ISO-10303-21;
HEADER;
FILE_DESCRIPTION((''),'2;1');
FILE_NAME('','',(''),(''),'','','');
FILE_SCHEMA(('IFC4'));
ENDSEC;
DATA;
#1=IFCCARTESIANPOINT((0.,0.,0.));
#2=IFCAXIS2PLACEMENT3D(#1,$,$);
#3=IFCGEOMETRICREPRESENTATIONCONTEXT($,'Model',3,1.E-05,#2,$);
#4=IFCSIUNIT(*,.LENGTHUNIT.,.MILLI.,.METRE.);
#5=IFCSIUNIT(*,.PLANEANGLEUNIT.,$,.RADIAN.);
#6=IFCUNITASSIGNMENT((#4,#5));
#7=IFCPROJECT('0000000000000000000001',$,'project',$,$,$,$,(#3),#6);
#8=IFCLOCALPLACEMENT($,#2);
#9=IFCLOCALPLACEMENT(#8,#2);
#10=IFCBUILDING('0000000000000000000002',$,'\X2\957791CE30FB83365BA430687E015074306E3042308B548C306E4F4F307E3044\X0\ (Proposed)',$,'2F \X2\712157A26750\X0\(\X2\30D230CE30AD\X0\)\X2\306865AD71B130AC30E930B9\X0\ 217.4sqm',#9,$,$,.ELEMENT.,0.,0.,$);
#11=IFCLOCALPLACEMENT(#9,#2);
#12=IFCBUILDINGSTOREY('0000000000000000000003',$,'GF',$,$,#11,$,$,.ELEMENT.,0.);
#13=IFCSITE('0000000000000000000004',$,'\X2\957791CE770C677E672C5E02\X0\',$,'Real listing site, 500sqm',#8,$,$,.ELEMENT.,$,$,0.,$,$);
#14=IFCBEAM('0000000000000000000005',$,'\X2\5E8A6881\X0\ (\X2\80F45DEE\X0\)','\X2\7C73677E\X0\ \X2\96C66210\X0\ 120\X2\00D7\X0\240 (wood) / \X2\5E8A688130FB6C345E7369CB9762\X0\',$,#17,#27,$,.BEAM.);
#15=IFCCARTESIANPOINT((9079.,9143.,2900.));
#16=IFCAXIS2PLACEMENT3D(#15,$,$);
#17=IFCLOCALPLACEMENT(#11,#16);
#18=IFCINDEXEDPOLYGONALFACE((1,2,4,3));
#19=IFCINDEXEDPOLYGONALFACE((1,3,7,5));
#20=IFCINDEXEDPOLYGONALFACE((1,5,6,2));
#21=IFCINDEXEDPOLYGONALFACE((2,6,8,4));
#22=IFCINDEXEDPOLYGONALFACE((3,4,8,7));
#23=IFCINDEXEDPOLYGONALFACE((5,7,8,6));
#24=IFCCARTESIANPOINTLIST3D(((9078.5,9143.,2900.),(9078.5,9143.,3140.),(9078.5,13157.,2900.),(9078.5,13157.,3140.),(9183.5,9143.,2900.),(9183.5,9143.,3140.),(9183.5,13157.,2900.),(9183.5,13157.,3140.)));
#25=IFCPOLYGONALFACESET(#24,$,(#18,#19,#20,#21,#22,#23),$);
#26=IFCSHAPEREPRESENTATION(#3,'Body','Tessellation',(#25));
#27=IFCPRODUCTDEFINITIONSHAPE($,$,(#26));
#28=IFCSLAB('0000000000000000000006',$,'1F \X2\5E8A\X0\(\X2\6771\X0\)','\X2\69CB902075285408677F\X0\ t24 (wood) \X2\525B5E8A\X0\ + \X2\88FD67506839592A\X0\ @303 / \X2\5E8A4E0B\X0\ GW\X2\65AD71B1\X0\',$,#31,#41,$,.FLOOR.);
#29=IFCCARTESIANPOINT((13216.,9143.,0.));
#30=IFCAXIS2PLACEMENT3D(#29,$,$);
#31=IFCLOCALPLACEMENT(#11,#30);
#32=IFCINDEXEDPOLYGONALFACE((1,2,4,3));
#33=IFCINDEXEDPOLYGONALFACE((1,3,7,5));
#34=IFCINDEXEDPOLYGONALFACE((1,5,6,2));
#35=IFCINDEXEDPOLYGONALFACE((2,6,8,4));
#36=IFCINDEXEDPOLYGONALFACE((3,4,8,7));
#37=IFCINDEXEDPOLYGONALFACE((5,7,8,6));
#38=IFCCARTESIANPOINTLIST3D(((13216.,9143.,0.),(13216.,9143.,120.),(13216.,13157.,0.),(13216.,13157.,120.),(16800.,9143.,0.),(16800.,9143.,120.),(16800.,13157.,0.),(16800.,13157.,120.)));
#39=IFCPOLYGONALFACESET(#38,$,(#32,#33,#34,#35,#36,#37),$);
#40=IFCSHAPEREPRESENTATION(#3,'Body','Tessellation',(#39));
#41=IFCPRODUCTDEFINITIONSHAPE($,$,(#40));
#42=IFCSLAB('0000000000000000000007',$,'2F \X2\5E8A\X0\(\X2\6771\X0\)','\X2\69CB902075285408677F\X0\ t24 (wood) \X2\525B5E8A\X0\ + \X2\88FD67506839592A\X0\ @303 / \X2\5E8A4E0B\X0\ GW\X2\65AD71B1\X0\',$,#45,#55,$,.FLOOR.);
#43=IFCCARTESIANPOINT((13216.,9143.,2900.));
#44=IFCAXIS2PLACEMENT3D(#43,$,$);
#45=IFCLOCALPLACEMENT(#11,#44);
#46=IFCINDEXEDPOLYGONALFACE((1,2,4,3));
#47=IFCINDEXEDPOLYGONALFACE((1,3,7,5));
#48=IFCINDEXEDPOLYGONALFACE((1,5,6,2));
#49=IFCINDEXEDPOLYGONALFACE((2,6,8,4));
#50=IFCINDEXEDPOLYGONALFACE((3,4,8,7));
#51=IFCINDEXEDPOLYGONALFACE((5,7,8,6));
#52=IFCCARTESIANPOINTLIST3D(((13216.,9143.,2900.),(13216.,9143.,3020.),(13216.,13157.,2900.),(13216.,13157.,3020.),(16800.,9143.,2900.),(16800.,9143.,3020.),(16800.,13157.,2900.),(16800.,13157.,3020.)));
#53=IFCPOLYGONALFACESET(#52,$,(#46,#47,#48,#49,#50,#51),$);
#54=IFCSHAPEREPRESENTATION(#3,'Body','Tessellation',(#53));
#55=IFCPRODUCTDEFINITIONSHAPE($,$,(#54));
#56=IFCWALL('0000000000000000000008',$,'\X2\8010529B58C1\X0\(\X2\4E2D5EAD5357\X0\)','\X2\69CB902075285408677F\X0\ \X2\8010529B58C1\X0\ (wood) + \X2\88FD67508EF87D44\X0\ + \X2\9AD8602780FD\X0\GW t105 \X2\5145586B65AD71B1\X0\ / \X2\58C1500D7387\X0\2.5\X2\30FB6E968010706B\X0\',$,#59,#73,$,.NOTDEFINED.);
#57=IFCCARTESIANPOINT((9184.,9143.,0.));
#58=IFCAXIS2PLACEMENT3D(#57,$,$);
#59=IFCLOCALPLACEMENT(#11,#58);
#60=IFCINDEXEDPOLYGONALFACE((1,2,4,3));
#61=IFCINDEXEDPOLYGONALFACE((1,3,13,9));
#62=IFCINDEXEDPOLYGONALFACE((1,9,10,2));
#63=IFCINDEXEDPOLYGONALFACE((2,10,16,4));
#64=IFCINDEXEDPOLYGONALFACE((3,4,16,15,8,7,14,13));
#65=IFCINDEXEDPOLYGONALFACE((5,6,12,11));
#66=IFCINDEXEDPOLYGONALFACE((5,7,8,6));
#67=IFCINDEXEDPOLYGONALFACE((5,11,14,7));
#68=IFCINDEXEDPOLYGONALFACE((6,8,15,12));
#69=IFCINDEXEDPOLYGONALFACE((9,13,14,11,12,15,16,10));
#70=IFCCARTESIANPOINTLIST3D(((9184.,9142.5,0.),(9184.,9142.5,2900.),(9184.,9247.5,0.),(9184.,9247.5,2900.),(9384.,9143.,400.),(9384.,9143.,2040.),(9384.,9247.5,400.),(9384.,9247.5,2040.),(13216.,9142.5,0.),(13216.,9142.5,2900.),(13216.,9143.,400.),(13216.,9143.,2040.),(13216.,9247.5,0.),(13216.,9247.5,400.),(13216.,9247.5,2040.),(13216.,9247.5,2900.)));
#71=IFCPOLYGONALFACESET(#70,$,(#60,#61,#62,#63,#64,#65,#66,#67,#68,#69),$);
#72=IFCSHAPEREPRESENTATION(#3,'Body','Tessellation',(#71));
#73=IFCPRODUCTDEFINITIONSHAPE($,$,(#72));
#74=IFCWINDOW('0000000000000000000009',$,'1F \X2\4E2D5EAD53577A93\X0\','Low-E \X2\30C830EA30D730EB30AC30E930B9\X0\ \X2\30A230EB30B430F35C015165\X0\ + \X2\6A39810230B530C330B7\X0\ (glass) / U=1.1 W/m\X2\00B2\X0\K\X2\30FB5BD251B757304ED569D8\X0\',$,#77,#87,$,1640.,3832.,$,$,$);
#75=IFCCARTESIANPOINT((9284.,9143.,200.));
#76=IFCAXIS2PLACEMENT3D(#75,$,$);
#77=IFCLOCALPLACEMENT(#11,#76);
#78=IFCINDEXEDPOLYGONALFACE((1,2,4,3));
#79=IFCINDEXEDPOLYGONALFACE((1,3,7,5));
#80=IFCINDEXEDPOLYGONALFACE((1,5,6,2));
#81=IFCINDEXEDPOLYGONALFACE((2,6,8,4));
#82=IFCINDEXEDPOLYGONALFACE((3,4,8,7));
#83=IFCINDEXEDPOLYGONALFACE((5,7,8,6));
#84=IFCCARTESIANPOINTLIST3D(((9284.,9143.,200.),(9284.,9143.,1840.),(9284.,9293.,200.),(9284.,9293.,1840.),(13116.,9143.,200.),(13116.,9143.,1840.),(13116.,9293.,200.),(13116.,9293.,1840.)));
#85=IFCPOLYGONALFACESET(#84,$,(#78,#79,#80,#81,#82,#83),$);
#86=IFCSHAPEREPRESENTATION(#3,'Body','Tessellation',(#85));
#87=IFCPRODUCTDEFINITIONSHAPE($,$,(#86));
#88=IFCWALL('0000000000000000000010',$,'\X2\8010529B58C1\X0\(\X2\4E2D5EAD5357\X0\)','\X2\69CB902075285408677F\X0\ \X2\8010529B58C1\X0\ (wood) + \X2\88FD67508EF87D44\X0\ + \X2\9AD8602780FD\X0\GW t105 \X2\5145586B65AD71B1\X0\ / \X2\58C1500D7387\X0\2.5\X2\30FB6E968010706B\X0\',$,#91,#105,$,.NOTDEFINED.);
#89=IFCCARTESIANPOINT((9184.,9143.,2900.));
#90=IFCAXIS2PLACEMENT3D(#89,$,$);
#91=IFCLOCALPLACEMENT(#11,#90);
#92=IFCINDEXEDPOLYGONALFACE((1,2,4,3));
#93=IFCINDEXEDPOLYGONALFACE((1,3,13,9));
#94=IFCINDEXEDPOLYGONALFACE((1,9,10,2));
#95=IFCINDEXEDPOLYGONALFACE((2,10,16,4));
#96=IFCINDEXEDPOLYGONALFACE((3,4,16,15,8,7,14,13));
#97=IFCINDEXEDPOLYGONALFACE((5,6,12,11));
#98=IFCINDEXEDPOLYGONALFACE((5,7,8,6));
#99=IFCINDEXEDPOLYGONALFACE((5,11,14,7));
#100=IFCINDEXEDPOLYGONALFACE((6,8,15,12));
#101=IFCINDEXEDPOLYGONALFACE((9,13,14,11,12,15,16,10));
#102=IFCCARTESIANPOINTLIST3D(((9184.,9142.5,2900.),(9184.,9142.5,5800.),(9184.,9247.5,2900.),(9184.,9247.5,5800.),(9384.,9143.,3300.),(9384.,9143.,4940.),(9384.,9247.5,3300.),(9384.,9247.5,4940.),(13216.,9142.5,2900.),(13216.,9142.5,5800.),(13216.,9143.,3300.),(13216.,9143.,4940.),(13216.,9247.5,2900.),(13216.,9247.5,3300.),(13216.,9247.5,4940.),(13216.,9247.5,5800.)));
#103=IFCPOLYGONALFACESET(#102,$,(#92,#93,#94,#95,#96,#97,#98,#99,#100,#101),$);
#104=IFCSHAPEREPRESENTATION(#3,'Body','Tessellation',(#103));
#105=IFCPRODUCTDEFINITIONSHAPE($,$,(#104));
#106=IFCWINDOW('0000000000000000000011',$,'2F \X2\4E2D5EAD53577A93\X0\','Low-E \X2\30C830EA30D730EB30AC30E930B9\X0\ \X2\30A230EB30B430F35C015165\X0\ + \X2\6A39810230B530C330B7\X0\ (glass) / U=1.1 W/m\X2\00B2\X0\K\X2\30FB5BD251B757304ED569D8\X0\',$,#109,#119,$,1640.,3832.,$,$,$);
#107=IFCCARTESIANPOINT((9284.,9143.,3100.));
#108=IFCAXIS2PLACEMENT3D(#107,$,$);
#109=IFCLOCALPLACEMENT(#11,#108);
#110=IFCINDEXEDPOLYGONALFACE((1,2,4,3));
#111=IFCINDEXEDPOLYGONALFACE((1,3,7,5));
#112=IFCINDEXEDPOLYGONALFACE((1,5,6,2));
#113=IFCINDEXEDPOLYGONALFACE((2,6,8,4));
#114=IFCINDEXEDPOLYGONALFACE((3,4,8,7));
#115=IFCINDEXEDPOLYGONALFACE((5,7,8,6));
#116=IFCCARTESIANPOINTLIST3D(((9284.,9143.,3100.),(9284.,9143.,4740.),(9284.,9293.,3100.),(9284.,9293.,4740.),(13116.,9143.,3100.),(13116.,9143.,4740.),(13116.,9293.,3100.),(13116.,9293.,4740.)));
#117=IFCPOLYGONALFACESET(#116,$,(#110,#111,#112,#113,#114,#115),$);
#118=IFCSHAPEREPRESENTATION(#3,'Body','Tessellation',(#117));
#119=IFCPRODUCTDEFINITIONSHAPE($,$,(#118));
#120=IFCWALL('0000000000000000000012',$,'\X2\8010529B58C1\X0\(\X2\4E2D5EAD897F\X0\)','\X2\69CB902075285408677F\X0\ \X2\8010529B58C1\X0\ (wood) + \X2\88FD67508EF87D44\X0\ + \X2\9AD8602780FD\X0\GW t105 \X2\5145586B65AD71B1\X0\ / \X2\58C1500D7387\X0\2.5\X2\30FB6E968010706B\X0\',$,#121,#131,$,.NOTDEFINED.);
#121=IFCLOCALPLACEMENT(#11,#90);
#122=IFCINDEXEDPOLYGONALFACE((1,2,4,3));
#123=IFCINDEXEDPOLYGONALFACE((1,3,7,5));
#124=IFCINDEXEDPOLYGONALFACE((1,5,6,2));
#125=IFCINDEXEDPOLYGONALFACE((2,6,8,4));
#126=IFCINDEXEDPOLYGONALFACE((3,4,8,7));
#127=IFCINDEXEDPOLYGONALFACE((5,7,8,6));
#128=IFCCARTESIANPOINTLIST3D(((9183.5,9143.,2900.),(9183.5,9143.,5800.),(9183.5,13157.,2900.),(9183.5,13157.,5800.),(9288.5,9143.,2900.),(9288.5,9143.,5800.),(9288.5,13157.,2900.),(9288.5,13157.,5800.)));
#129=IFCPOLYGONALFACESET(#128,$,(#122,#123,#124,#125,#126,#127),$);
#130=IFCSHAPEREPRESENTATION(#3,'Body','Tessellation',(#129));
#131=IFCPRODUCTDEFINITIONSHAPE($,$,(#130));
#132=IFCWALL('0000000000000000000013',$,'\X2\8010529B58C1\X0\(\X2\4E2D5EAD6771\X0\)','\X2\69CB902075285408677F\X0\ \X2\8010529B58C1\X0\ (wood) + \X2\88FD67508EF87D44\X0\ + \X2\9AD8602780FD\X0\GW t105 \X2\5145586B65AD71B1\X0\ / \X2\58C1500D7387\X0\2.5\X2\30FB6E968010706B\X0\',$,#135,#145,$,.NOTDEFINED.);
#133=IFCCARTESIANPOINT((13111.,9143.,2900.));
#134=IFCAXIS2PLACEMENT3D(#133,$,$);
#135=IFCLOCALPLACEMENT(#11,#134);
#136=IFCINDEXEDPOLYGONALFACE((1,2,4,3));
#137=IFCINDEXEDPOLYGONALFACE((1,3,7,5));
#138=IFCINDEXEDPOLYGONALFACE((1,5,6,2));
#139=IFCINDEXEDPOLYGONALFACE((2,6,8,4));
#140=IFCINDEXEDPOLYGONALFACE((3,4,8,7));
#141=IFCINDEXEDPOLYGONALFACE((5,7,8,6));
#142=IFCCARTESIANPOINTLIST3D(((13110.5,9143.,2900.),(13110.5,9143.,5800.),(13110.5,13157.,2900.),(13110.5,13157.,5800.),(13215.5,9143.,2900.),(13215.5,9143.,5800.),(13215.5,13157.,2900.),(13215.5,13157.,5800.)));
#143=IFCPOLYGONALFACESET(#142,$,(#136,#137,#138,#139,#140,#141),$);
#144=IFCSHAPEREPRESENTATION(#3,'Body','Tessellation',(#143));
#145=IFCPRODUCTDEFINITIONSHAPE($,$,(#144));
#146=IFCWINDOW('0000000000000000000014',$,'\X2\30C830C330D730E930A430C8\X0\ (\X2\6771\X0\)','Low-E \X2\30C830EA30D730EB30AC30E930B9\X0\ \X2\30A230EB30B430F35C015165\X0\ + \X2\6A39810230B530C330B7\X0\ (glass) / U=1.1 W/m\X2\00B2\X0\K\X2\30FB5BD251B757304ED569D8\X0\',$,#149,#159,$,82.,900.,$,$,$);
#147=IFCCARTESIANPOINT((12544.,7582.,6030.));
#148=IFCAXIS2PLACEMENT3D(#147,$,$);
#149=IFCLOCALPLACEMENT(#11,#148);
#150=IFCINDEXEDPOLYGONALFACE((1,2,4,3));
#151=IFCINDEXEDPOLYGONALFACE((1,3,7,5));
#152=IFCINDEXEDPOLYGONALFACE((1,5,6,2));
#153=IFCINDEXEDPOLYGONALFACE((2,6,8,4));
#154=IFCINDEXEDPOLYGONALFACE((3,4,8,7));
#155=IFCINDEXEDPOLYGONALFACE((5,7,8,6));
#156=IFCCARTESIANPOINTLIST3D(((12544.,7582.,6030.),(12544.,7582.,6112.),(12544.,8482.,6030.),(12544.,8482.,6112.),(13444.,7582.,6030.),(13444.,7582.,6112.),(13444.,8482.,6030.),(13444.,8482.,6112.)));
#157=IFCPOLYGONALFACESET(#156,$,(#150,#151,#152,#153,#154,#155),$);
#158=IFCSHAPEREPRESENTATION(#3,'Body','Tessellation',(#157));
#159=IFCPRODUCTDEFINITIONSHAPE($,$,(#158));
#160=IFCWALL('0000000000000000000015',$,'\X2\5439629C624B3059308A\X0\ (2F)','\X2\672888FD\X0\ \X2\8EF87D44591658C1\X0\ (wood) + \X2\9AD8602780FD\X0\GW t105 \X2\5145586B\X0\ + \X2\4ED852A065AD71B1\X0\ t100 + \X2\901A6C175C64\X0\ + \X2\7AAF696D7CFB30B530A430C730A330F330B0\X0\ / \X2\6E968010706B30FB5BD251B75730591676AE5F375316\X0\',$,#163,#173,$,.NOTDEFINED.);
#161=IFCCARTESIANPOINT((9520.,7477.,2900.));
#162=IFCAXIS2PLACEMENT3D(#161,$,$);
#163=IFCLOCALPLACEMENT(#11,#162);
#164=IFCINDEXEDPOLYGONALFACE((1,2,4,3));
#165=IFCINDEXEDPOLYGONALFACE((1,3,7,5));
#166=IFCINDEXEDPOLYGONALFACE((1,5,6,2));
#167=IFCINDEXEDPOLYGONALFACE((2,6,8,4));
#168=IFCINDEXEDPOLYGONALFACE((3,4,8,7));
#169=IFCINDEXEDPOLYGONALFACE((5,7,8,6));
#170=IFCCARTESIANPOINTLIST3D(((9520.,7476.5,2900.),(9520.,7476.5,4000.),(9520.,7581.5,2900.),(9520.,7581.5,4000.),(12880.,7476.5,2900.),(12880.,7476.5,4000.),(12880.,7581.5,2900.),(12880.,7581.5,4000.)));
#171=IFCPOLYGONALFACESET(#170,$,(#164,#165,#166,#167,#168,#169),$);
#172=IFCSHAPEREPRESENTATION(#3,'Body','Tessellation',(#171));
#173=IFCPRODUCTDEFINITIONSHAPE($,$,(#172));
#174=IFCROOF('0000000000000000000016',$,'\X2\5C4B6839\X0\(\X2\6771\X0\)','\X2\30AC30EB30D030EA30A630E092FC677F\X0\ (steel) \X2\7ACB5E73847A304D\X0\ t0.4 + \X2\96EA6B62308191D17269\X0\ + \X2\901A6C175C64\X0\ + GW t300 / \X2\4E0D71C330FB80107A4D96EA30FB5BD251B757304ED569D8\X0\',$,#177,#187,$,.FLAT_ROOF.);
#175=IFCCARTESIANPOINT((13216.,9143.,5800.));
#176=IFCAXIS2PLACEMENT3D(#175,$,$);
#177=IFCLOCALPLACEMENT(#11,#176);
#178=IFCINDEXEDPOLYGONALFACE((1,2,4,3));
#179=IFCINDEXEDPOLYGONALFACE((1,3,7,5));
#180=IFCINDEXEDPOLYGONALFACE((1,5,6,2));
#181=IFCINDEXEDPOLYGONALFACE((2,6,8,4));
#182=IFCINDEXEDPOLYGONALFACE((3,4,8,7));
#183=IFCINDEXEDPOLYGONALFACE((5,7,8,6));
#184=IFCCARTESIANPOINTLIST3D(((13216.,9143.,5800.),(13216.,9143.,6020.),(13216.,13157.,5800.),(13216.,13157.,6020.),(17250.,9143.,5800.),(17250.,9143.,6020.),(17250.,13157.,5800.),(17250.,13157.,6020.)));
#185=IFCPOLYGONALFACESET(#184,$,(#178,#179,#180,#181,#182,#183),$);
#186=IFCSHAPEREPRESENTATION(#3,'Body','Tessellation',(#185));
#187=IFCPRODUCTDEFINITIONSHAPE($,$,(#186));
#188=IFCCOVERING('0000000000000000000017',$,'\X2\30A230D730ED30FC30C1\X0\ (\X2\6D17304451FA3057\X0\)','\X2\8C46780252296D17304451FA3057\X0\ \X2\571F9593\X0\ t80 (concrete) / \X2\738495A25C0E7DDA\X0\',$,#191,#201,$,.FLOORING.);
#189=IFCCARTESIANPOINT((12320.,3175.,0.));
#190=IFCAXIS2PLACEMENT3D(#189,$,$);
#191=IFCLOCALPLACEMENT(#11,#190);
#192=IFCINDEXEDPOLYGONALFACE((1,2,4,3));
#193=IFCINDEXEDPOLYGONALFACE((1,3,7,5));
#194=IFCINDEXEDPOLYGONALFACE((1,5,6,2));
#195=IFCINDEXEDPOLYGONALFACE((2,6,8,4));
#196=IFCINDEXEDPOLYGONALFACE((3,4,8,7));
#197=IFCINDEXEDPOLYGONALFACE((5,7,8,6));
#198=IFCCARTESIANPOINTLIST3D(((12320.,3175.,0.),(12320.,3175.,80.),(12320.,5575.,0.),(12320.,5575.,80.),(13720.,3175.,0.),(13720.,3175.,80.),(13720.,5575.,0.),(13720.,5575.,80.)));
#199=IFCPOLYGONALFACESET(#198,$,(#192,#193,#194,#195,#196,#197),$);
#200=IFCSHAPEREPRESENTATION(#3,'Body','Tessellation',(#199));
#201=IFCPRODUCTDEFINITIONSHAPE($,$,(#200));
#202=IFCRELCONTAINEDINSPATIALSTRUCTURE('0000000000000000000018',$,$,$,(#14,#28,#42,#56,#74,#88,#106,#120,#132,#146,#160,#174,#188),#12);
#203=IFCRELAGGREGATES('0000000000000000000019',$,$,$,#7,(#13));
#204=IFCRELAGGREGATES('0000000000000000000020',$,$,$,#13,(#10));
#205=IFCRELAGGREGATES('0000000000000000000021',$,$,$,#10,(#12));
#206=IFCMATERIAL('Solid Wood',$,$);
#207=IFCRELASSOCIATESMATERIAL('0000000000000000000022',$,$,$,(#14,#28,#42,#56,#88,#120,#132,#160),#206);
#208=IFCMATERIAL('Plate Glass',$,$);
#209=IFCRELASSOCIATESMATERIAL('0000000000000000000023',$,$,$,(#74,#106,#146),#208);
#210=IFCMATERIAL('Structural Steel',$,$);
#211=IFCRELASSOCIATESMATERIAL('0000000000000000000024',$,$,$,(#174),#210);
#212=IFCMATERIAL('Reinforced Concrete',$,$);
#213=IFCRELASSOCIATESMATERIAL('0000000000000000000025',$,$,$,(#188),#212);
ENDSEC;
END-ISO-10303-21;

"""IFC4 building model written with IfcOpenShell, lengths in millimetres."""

from ifc_helpers import new_model, si_unit, frame, frame_2d, origin, place, context, project, spatial, rectangle, extrude, material, element, fill, save


model = new_model("IFC4")

# Units and contexts
model_context = context("Model", 3, precision=1e-05, world=origin())
ifc_project = project(units=[si_unit("LENGTHUNIT", "METRE", prefix="MILLI"), si_unit("PLANEANGLEUNIT", "RADIAN")], contexts=[model_context])

# Site, building, storey
site_placement = place(None, origin())
site = spatial("IfcSite", under=ifc_project, at=site_placement, Name="長野県松本市", ObjectType="Real listing site, 500sqm", CompositionType="ELEMENT", RefElevation=0.0)
building_placement = place(site_placement, origin())
building = spatial("IfcBuilding", under=site, at=building_placement, Name="長野・茶室と縁側のある和の住まい (Proposed)", ObjectType="2F 無垢材(ヒノキ)と断熱ガラス 217.4sqm", CompositionType="ELEMENT", ElevationOfRefHeight=0.0, ElevationOfTerrain=0.0)
storey_placement = place(building_placement, origin())
storey = spatial("IfcBuildingStorey", under=building, at=storey_placement, Name="GF", CompositionType="ELEMENT", Elevation=0.0)

# Shared definitions
ifc_material_1 = material(Name="Solid Wood")

# Beam
beam_placement = place(storey_placement, frame((9079.0, 9143.0, 2900.0)))
element("IfcBeam", 1, at=beam_placement, inside=storey, material=ifc_material_1, Name="床梁 (胴差)", Description="米松 集成 120×240 (wood) / 床梁・水平構面", PredefinedType="BEAM", context=model_context, shape_type="SweptSolid", body=[
    extrude(rectangle(XDim=105.0, YDim=4014.0, at=frame_2d((52.0, 2007.0))), frame((9079.0, 9143.0, 2900.0)), (0.0, 0.0, 1.0), 240.0),
])

# Slabs
slab_1_placement = place(storey_placement, frame((13216.0, 9143.0, 0.0)))
element("IfcSlab", 2, at=slab_1_placement, inside=storey, material=ifc_material_1, Name="1F 床(東)", Description="構造用合板 t24 (wood) 剛床 + 製材根太 @303 / 床下 GW断熱", PredefinedType="FLOOR", context=model_context, shape_type="SweptSolid", body=[
    extrude(rectangle(XDim=3584.0, YDim=4014.0, at=frame_2d((1792.0, 2007.0))), frame((13216.0, 9143.0, 0.0)), (0.0, 0.0, 1.0), 120.0),
])
slab_2_placement = place(storey_placement, frame((13216.0, 9143.0, 2900.0)))
element("IfcSlab", 3, at=slab_2_placement, inside=storey, material=ifc_material_1, Name="2F 床(東)", Description="構造用合板 t24 (wood) 剛床 + 製材根太 @303 / 床下 GW断熱", PredefinedType="FLOOR", context=model_context, shape_type="SweptSolid", body=[
    extrude(rectangle(XDim=3584.0, YDim=4014.0, at=frame_2d((1792.0, 2007.0))), frame((13216.0, 9143.0, 2900.0)), (0.0, 0.0, 1.0), 120.0),
])

# Wall, opening, window
wall_1_placement = place(storey_placement, frame((9184.0, 9143.0, 0.0)))
wall_1 = element("IfcWall", 4, at=wall_1_placement, inside=storey, material=ifc_material_1, Name="耐力壁(中庭南)", Description="構造用合板 耐力壁 (wood) + 製材軸組 + 高性能GW t105 充填断熱 / 壁倍率2.5・準耐火", PredefinedType="NOTDEFINED", context=model_context, shape_type="SweptSolid", body=[
    extrude(rectangle(XDim=4032.0, YDim=105.0, at=frame_2d((2016.0, 52.0))), frame((9184.0, 9143.0, 0.0)), (0.0, 0.0, 1.0), 2900.0),
])
opening_1_placement = place(storey_placement, frame((9284.0, 9143.0, 200.0)))
opening_1 = element("IfcOpeningElement", 5, at=opening_1_placement, cuts=wall_1, PredefinedType="NOTDEFINED", context=model_context, shape_type="SweptSolid", body=[
    extrude(rectangle(XDim=3832.0, YDim=150.0, at=frame_2d((1916.0, 75.0))), frame((9284.0, 9143.0, 200.0)), (0.0, 0.0, 1.0), 1640.0),
])
ifc_material_2 = material(Name="Plate Glass")
window_1_placement = place(storey_placement, frame((9284.0, 9143.0, 200.0)))
window_1 = element("IfcWindow", 6, at=window_1_placement, inside=storey, material=ifc_material_2, Name="1F 中庭南窓", Description="Low-E トリプルガラス アルゴン封入 + 樹脂サッシ (glass) / U=1.1 W/m²K・寒冷地仕様", OverallHeight=1640.0, OverallWidth=3832.0, context=model_context, shape_type="SweptSolid", body=[
    extrude(rectangle(XDim=3832.0, YDim=150.0, at=frame_2d((1916.0, 75.0))), frame((9284.0, 9143.0, 200.0)), (0.0, 0.0, 1.0), 1640.0),
])
fill(opening_1, window_1)

# Wall, opening, window
wall_2_placement = place(storey_placement, frame((9184.0, 9143.0, 2900.0)))
wall_2 = element("IfcWall", 7, at=wall_2_placement, inside=storey, material=ifc_material_1, Name="耐力壁(中庭南)", Description="構造用合板 耐力壁 (wood) + 製材軸組 + 高性能GW t105 充填断熱 / 壁倍率2.5・準耐火", PredefinedType="NOTDEFINED", context=model_context, shape_type="SweptSolid", body=[
    extrude(rectangle(XDim=4032.0, YDim=105.0, at=frame_2d((2016.0, 52.0))), frame((9184.0, 9143.0, 2900.0)), (0.0, 0.0, 1.0), 2900.0),
])
opening_2_placement = place(storey_placement, frame((9284.0, 9143.0, 3100.0)))
opening_2 = element("IfcOpeningElement", 8, at=opening_2_placement, cuts=wall_2, PredefinedType="NOTDEFINED", context=model_context, shape_type="SweptSolid", body=[
    extrude(rectangle(XDim=3832.0, YDim=150.0, at=frame_2d((1916.0, 75.0))), frame((9284.0, 9143.0, 3100.0)), (0.0, 0.0, 1.0), 1640.0),
])
window_2_placement = place(storey_placement, frame((9284.0, 9143.0, 3100.0)))
window_2 = element("IfcWindow", 9, at=window_2_placement, inside=storey, material=ifc_material_2, Name="2F 中庭南窓", Description="Low-E トリプルガラス アルゴン封入 + 樹脂サッシ (glass) / U=1.1 W/m²K・寒冷地仕様", OverallHeight=1640.0, OverallWidth=3832.0, context=model_context, shape_type="SweptSolid", body=[
    extrude(rectangle(XDim=3832.0, YDim=150.0, at=frame_2d((1916.0, 75.0))), frame((9284.0, 9143.0, 3100.0)), (0.0, 0.0, 1.0), 1640.0),
])
fill(opening_2, window_2)

# Walls
wall_3_placement = place(storey_placement, frame((9184.0, 9143.0, 2900.0)))
element("IfcWall", 10, at=wall_3_placement, inside=storey, material=ifc_material_1, Name="耐力壁(中庭西)", Description="構造用合板 耐力壁 (wood) + 製材軸組 + 高性能GW t105 充填断熱 / 壁倍率2.5・準耐火", PredefinedType="NOTDEFINED", context=model_context, shape_type="SweptSolid", body=[
    extrude(rectangle(XDim=105.0, YDim=4014.0, at=frame_2d((52.0, 2007.0))), frame((9184.0, 9143.0, 2900.0)), (0.0, 0.0, 1.0), 2900.0),
])
wall_4_placement = place(storey_placement, frame((13111.0, 9143.0, 2900.0)))
element("IfcWall", 11, at=wall_4_placement, inside=storey, material=ifc_material_1, Name="耐力壁(中庭東)", Description="構造用合板 耐力壁 (wood) + 製材軸組 + 高性能GW t105 充填断熱 / 壁倍率2.5・準耐火", PredefinedType="NOTDEFINED", context=model_context, shape_type="SweptSolid", body=[
    extrude(rectangle(XDim=105.0, YDim=4014.0, at=frame_2d((52.0, 2007.0))), frame((13111.0, 9143.0, 2900.0)), (0.0, 0.0, 1.0), 2900.0),
])

# Window
window_3_placement = place(storey_placement, frame((12544.0, 7582.0, 6030.0)))
element("IfcWindow", 12, at=window_3_placement, inside=storey, material=ifc_material_2, Name="トップライト (東)", Description="Low-E トリプルガラス アルゴン封入 + 樹脂サッシ (glass) / U=1.1 W/m²K・寒冷地仕様", OverallHeight=82.0, OverallWidth=900.0, context=model_context, shape_type="SweptSolid", body=[
    extrude(rectangle(XDim=900.0, YDim=900.0, at=frame_2d((450.0, 450.0))), frame((12544.0, 7582.0, 6030.0)), (0.0, 0.0, 1.0), 82.0),
])

# Wall
wall_5_placement = place(storey_placement, frame((9520.0, 7477.0, 2900.0)))
element("IfcWall", 13, at=wall_5_placement, inside=storey, material=ifc_material_1, Name="吹抜手すり (2F)", Description="木製 軸組外壁 (wood) + 高性能GW t105 充填 + 付加断熱 t100 + 通気層 + 窯業系サイディング / 準耐火・寒冷地外皮強化", PredefinedType="NOTDEFINED", context=model_context, shape_type="SweptSolid", body=[
    extrude(rectangle(XDim=3360.0, YDim=105.0, at=frame_2d((1680.0, 52.0))), frame((9520.0, 7477.0, 2900.0)), (0.0, 0.0, 1.0), 1100.0),
])

# Roof
ifc_material_3 = material(Name="Structural Steel")
roof_placement = place(storey_placement, frame((13216.0, 9143.0, 5800.0)))
element("IfcRoof", 14, at=roof_placement, inside=storey, material=ifc_material_3, Name="屋根(東)", Description="ガルバリウム鋼板 (steel) 立平葺き t0.4 + 雪止め金物 + 通気層 + GW t300 / 不燃・耐積雪・寒冷地仕様", PredefinedType="FLAT_ROOF", context=model_context, shape_type="SweptSolid", body=[
    extrude(rectangle(XDim=4034.0, YDim=4014.0, at=frame_2d((2017.0, 2007.0))), frame((13216.0, 9143.0, 5800.0)), (0.0, 0.0, 1.0), 220.0),
])

# Covering
ifc_material_4 = material(Name="Reinforced Concrete")
covering_placement = place(storey_placement, frame((12320.0, 3175.0, 0.0)))
element("IfcCovering", 15, at=covering_placement, inside=storey, material=ifc_material_4, Name="アプローチ (洗い出し)", Description="豆砂利洗い出し 土間 t80 (concrete) / 玄関導線", PredefinedType="FLOORING", context=model_context, shape_type="SweptSolid", body=[
    extrude(rectangle(XDim=1400.0, YDim=2400.0, at=frame_2d((700.0, 1200.0))), frame((12320.0, 3175.0, 0.0)), (0.0, 0.0, 1.0), 80.0),
])

save(model, "model.ifc")
